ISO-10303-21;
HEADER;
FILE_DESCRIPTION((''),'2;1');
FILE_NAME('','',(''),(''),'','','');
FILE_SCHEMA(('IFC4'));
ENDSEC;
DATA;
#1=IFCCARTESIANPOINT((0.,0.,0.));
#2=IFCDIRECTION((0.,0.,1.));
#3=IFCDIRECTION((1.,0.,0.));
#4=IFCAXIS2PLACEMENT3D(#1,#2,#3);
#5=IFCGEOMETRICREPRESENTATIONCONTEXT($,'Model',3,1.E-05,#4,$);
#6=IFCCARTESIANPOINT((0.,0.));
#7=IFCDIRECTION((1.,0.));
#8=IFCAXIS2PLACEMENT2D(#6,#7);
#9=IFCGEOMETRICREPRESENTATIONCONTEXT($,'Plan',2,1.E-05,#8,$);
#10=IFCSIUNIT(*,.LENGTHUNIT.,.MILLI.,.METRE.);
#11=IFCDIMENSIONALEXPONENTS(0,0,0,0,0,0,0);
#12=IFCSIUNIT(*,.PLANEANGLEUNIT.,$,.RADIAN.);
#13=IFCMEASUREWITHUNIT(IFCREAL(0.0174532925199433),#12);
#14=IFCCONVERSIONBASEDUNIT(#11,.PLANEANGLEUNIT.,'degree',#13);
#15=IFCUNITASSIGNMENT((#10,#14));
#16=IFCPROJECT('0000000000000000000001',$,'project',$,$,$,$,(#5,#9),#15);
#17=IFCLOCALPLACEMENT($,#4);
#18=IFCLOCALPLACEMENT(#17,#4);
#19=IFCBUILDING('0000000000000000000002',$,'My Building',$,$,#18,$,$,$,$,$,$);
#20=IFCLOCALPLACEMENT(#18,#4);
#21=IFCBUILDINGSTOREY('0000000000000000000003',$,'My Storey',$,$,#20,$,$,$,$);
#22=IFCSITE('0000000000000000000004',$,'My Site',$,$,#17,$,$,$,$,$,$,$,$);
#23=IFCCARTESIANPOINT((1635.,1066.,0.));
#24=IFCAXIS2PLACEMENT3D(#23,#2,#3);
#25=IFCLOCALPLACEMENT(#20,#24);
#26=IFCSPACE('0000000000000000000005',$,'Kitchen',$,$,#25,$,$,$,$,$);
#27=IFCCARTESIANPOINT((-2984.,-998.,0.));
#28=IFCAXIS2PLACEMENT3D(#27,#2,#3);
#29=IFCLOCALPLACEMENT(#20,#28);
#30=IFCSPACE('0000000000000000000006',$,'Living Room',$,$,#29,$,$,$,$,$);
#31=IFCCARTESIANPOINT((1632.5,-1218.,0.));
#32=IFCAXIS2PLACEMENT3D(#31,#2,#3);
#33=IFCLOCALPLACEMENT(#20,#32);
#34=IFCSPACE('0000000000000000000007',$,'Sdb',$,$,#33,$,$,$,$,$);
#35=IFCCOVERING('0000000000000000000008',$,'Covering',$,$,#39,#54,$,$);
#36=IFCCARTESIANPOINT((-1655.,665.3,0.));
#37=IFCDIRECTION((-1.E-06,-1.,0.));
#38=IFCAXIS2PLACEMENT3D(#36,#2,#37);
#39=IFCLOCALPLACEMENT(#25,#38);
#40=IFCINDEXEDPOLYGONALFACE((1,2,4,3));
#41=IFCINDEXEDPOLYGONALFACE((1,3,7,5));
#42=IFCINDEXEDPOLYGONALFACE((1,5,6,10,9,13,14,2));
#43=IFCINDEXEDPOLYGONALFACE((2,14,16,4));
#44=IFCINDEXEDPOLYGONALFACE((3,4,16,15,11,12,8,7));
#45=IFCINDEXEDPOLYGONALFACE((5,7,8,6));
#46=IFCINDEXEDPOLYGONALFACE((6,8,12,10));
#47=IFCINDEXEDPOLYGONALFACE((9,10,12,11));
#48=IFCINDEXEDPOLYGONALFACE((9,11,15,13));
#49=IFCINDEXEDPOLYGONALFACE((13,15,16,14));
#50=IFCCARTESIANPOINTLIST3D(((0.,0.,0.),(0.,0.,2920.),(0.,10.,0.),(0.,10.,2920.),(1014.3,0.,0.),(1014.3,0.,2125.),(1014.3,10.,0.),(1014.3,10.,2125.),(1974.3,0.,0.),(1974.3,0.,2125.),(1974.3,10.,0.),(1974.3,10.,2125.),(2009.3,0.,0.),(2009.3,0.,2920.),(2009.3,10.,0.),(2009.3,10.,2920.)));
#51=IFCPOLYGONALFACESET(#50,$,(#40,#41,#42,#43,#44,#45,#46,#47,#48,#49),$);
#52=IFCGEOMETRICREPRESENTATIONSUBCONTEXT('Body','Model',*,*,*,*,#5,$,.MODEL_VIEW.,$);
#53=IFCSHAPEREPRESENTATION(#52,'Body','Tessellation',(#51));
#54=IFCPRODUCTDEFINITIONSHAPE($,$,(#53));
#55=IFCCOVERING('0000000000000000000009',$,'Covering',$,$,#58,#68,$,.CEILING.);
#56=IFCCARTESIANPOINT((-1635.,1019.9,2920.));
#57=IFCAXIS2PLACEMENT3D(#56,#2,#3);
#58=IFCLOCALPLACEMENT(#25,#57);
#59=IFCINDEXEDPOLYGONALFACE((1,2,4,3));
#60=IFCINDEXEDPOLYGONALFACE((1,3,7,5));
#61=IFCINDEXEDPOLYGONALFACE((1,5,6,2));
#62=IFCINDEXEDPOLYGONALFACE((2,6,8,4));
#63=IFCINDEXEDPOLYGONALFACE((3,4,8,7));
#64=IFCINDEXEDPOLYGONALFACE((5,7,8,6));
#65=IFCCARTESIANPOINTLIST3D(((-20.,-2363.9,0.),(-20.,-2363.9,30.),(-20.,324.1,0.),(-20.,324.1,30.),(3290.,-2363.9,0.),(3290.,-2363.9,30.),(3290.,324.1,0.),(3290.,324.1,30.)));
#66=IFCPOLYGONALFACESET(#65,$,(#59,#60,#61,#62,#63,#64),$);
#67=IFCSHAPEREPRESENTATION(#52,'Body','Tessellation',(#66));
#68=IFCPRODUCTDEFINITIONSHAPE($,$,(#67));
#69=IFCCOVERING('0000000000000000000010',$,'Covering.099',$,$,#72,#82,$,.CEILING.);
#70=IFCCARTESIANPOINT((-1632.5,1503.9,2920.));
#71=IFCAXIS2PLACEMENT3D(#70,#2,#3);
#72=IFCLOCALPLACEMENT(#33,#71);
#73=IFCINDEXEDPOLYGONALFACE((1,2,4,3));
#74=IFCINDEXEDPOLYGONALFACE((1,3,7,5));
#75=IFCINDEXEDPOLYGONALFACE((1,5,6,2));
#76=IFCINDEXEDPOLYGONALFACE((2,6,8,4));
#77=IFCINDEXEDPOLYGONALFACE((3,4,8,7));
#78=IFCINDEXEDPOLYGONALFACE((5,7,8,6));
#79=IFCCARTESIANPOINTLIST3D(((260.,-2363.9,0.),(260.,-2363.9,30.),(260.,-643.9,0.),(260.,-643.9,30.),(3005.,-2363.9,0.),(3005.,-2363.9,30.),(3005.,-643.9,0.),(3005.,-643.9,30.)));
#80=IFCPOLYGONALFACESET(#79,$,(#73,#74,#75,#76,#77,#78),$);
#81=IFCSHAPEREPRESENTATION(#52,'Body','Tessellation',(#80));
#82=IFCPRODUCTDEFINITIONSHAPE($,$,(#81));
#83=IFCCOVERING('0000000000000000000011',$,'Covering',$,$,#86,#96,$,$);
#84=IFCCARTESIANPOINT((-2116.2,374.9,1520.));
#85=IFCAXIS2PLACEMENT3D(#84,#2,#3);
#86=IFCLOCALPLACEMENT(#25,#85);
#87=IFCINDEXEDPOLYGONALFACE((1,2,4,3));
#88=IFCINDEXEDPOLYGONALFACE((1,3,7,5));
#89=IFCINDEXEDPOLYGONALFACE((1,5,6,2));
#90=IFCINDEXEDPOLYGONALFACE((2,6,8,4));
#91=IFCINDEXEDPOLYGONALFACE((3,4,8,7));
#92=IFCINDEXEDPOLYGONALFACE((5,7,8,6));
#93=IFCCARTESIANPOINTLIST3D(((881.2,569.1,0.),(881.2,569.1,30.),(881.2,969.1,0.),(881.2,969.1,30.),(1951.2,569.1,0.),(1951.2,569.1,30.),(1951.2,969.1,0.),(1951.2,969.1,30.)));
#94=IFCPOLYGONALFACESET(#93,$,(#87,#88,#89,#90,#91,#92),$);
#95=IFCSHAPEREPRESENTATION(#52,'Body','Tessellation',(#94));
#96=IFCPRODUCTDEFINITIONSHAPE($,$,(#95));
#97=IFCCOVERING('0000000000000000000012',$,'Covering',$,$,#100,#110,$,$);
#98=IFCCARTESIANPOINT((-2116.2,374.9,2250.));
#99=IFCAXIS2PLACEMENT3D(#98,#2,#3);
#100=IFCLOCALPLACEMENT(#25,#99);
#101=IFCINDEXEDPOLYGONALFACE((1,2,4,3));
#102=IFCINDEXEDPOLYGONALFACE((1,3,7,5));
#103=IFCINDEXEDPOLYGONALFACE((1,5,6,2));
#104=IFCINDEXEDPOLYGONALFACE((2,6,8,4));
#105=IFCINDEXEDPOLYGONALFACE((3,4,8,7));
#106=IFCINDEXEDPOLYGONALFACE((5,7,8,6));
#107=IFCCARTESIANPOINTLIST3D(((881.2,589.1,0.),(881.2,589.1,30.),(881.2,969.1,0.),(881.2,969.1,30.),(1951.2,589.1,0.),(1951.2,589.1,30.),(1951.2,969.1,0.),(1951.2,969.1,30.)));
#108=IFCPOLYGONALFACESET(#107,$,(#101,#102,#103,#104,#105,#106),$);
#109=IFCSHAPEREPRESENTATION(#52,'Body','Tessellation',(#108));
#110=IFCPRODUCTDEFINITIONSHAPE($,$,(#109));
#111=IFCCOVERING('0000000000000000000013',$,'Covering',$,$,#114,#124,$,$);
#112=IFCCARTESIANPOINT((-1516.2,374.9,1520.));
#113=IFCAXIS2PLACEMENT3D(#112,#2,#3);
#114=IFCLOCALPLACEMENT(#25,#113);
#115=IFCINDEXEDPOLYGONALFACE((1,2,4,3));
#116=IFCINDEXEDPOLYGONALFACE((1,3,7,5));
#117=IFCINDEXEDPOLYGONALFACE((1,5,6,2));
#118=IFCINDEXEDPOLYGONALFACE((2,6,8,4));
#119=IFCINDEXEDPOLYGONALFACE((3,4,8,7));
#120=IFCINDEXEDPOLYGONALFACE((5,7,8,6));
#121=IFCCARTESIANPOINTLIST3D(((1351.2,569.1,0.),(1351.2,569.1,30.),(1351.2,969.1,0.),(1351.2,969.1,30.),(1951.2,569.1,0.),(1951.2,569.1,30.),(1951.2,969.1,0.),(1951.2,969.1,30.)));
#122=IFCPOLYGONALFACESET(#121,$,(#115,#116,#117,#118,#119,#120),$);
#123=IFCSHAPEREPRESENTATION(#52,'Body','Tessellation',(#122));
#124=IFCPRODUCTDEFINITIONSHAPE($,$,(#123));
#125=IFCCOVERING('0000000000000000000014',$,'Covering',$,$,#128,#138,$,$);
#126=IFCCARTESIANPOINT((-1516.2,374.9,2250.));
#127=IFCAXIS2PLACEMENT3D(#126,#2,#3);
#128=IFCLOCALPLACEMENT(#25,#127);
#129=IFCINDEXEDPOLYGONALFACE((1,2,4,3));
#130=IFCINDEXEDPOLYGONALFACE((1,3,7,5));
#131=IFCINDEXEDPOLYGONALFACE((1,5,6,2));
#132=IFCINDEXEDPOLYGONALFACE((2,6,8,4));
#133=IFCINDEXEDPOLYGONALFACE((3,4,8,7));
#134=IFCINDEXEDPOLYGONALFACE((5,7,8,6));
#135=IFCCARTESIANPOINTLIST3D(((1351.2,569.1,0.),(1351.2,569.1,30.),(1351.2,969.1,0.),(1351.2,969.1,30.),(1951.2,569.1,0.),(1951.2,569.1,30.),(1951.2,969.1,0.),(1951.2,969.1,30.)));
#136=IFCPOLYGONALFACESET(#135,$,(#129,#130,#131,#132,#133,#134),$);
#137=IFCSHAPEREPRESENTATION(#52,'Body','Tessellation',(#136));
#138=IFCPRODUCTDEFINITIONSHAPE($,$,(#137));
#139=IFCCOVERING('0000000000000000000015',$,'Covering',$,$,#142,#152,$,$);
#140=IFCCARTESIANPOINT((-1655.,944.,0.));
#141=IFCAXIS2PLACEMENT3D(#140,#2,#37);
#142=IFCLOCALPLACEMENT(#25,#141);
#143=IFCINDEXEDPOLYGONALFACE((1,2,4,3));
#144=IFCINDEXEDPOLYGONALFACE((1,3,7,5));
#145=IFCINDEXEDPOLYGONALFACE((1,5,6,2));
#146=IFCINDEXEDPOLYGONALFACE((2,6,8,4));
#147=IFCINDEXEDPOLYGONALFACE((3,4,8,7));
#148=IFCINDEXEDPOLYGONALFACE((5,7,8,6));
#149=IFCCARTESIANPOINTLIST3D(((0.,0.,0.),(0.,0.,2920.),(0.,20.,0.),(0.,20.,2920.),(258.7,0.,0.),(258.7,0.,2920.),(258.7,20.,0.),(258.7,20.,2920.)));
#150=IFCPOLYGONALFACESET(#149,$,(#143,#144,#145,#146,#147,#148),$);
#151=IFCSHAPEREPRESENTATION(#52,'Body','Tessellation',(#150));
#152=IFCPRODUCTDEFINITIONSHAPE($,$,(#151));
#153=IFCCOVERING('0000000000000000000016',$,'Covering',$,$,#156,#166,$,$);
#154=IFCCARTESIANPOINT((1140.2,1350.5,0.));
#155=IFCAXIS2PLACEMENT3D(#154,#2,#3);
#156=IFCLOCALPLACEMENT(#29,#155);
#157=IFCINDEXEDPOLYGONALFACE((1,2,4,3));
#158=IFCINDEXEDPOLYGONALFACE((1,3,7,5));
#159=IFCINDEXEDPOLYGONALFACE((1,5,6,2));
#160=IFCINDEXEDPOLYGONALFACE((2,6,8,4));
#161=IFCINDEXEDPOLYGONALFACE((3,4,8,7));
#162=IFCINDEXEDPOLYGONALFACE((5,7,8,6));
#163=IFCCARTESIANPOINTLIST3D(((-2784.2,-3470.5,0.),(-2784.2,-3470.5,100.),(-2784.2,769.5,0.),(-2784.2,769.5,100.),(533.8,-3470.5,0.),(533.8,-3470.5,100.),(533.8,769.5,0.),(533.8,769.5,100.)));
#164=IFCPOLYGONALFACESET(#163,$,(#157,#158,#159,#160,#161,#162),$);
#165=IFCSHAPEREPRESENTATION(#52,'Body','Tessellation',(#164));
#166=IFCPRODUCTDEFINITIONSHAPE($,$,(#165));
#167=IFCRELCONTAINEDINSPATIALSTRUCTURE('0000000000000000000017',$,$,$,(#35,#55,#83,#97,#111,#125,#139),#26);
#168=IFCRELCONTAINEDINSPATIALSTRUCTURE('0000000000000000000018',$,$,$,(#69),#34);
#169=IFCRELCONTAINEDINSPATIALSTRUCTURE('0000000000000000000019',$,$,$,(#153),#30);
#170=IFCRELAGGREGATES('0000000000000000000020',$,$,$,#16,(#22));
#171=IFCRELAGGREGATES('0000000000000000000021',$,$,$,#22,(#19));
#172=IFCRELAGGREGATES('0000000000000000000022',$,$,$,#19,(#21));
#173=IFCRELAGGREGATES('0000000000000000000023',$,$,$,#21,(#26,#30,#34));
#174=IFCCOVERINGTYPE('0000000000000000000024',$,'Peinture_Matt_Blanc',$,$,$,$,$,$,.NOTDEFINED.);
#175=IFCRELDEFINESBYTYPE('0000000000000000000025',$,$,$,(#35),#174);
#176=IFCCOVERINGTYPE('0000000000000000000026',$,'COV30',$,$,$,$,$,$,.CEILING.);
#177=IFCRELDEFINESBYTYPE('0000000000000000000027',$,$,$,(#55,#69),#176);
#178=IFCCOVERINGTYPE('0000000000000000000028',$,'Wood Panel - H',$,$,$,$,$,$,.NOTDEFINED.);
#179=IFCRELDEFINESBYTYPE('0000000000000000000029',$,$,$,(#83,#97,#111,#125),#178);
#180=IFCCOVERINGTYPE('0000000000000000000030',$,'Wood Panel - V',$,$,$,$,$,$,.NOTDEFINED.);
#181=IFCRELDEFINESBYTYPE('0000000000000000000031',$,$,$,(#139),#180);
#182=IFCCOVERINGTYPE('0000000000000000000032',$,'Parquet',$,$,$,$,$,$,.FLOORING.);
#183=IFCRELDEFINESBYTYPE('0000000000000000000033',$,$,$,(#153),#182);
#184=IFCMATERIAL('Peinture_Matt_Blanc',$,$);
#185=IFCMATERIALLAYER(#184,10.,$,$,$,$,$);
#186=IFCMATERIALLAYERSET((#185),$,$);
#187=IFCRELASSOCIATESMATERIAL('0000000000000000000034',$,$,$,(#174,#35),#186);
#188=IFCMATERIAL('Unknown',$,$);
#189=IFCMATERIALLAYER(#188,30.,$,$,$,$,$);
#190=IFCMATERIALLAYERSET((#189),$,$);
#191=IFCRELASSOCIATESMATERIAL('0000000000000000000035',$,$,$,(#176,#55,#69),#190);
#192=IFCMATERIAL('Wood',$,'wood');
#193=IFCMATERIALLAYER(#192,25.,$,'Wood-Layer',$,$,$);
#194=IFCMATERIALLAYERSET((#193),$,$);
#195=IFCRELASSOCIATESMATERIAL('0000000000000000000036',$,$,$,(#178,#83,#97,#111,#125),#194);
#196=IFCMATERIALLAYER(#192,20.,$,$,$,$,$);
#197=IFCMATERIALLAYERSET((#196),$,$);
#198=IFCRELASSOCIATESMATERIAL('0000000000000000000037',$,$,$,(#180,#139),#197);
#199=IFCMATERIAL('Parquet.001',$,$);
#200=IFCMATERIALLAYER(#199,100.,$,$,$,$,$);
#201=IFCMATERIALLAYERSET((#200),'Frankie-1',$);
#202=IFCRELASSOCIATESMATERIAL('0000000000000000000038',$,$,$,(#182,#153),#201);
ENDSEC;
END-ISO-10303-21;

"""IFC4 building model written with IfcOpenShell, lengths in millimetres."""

from ifc_helpers import new_model, entity, si_unit, converted_unit, frame, origin_with_axes, origin_2d_with_axis, place, context, subcontext, project, spatial, line, indexed_curve, outline, extrude, clip, halfspace, source, transform, mapped, material, layer, layer_set, layer_usage, type_object, element, save


model = new_model("IFC4")

# Units and contexts
model_context = context("Model", 3, precision=1e-05, world=origin_with_axes())
plan_context = context("Plan", 2, precision=1e-05, world=origin_2d_with_axis())
body_context_1 = subcontext(model_context, "Body", "Model", "MODEL_VIEW")
ifc_project = project(units=[si_unit("LENGTHUNIT", "METRE", prefix="MILLI"), converted_unit("PLANEANGLEUNIT", "degree", entity("IfcReal", 0.0174532925199433), si_unit("PLANEANGLEUNIT", "RADIAN"), dimensions=[0, 0, 0, 0, 0, 0, 0])], contexts=[model_context, plan_context])

# Site, building, storey
site_placement = place(None, origin_with_axes())
site = spatial("IfcSite", under=ifc_project, at=site_placement, Name="My Site")
building_placement = place(site_placement, origin_with_axes())
building = spatial("IfcBuilding", under=site, at=building_placement, Name="My Building")
storey_placement = place(building_placement, origin_with_axes())
storey = spatial("IfcBuildingStorey", under=building, at=storey_placement, Name="My Storey")

# Shared definitions
ifc_material_1 = material(Name="Unknown")

# Shared definitions
space_1_placement = place(storey_placement, frame((1635.0, 1066.0, 0.0), z_axis=(0.0, 0.0, 1.0), x_axis=(1.0, 0.0, 0.0)))
space_1 = spatial("IfcSpace", under=storey, at=space_1_placement, Name="Kitchen")

# Shared definitions
ifc_material_2 = material(Name="Peinture_Matt_Blanc")
ifc_layer_1 = layer(ifc_material_2, 10.0)
ifc_layer_set_1 = layer_set([ifc_layer_1])
covering_type_1 = type_object("IfcCoveringType", Name="Peinture_Matt_Blanc", PredefinedType="NOTDEFINED", material=ifc_layer_set_1)

# Shared definitions
space_2_placement = place(storey_placement, frame((-2984.0, -998.0, 0.0), z_axis=(0.0, 0.0, 1.0), x_axis=(1.0, 0.0, 0.0)))
space_2 = spatial("IfcSpace", under=storey, at=space_2_placement, Name="Living Room")

# Covering, opening
ifc_layer_usage_1 = layer_usage(ifc_layer_set_1, "AXIS2", "POSITIVE", 0.0)
covering_1_placement = place(space_1_placement, frame((-1655.0, 665.3, 0.0), z_axis=(0.0, 0.0, 1.0), x_axis=(-0.000001, -1.0, 0.0)))
covering_1 = element("IfcCovering", 1, at=covering_1_placement, inside=space_1, type_object=covering_type_1, material=ifc_layer_usage_1, Name="Covering", context=body_context_1, shape_type="Clipping", body=[
    clip(clip(extrude(outline(indexed_curve([(0.0, 0.0), (0.0, 10.0), (2009.3, 10.0), (2009.3, 0.0), (0.0, 0.0)], self_intersect=False)), origin_with_axes(), (0.0, 0.0, 1.0), 2920.0), halfspace(frame((0.0, 0.0, 2920.0), z_axis=(0.0, 0.0, 1.0), x_axis=(-1.0, 0.0, 0.0)), False)), halfspace(frame((0.0, 0.0, 2920.0), z_axis=(0.0, 0.0, 1.0), x_axis=(-1.0, 0.0, 0.0)), False)),
])
shared_shape_1 = source(origin_with_axes(), body_context_1, "Body", "SweptSolid", [
    extrude(outline(indexed_curve([(0.0, 0.0), (960.0, 0.0), (960.0, 2125.0), (0.0, 2125.0)], segments=[line(4, 1), line(1, 2), line(2, 3), line(3, 4)], self_intersect=False)), frame((0.0, -600.0, 0.0), z_axis=(0.0, -1.0, 0.0), x_axis=(1.0, 0.0, 0.0)), (0.0, 0.0, -1.0), 1200.0),
])
opening_1_placement = place(covering_1_placement, frame((1974.3, 0.0, 0.0), z_axis=(0.0, 0.0, 1.0), x_axis=(-1.0, 0.0, 0.0)))
element("IfcOpeningElement", 2, at=opening_1_placement, cuts=covering_1, PredefinedType="OPENING", context=body_context_1, shape_type="MappedRepresentation", body=[
    mapped(shared_shape_1, transform((0.0, 0.0, 0.0), x_axis=(1.0, 0.0, 0.0), y_axis=(0.0, 1.0, 0.0), z_axis=(0.0, 0.0, 1.0), scale=1.0)),
])

# Covering
ifc_layer_2 = layer(ifc_material_1, 30.0)
ifc_layer_set_2 = layer_set([ifc_layer_2])
ifc_layer_usage_2 = layer_usage(ifc_layer_set_2, "AXIS3", "POSITIVE", 0.0)
covering_type_2 = type_object("IfcCoveringType", Name="COV30", PredefinedType="CEILING", material=ifc_layer_set_2)
covering_2_placement = place(space_1_placement, frame((-1635.0, 1019.9, 2920.0), z_axis=(0.0, 0.0, 1.0), x_axis=(1.0, 0.0, 0.0)))
element("IfcCovering", 3, at=covering_2_placement, inside=space_1, type_object=covering_type_2, material=ifc_layer_usage_2, Name="Covering", PredefinedType="CEILING", context=body_context_1, shape_type="SweptSolid", body=[
    extrude(outline(indexed_curve([(-20.0, 324.1), (-20.0, -2363.9), (3290.0, -2363.9), (3290.0, 324.1)], segments=[line(3, 2), line(2, 1), line(1, 4), line(4, 3)], self_intersect=False)), None, (0.0, 0.0, 1.0), 30.0),
])

# Shared definitions
space_3_placement = place(storey_placement, frame((1632.5, -1218.0, 0.0), z_axis=(0.0, 0.0, 1.0), x_axis=(1.0, 0.0, 0.0)))
space_3 = spatial("IfcSpace", under=storey, at=space_3_placement, Name="Sdb")

# Coverings
ifc_layer_usage_3 = layer_usage(ifc_layer_set_2, "AXIS3", "POSITIVE", 0.0)
covering_3_placement = place(space_3_placement, frame((-1632.5, 1503.9, 2920.0), z_axis=(0.0, 0.0, 1.0), x_axis=(1.0, 0.0, 0.0)))
element("IfcCovering", 4, at=covering_3_placement, inside=space_3, type_object=covering_type_2, material=ifc_layer_usage_3, Name="Covering.099", PredefinedType="CEILING", context=body_context_1, shape_type="SweptSolid", body=[
    extrude(outline(indexed_curve([(3005.0, -2363.9), (260.0, -2363.9), (260.0, -643.9), (3005.0, -643.9)], segments=[line(3, 2), line(2, 1), line(1, 4), line(4, 3)], self_intersect=False)), None, (0.0, 0.0, 1.0), 30.0),
])
ifc_material_3 = material(Name="Wood", Category="wood")
ifc_layer_3 = layer(ifc_material_3, 25.0, Name="Wood-Layer")
ifc_layer_set_3 = layer_set([ifc_layer_3])
ifc_layer_usage_4 = layer_usage(ifc_layer_set_3, "AXIS3", "POSITIVE", 0.0)
covering_type_3 = type_object("IfcCoveringType", Name="Wood Panel - H", PredefinedType="NOTDEFINED", material=ifc_layer_set_3)
covering_4_placement = place(space_1_placement, frame((-2116.2, 374.9, 1520.0), z_axis=(0.0, 0.0, 1.0), x_axis=(1.0, 0.0, 0.0)))
element("IfcCovering", 5, at=covering_4_placement, inside=space_1, type_object=covering_type_3, material=ifc_layer_usage_4, Name="Covering", context=body_context_1, shape_type="SweptSolid", body=[
    extrude(outline(indexed_curve([(1951.2, 969.1), (1951.2, 569.1), (881.2, 569.1), (881.2, 969.1)], segments=[line(3, 2), line(2, 1), line(1, 4), line(4, 3)], self_intersect=False)), None, (0.0, 0.0, 1.0), 30.0),
])
ifc_layer_usage_5 = layer_usage(ifc_layer_set_3, "AXIS3", "POSITIVE", 0.0)
covering_5_placement = place(space_1_placement, frame((-2116.2, 374.9, 2250.0), z_axis=(0.0, 0.0, 1.0), x_axis=(1.0, 0.0, 0.0)))
element("IfcCovering", 6, at=covering_5_placement, inside=space_1, type_object=covering_type_3, material=ifc_layer_usage_5, Name="Covering", context=body_context_1, shape_type="SweptSolid", body=[
    extrude(outline(indexed_curve([(1951.2, 969.1), (1951.2, 589.1), (881.2, 589.1), (881.2, 969.1)], segments=[line(3, 2), line(2, 1), line(1, 4), line(4, 3)], self_intersect=False)), None, (0.0, 0.0, 1.0), 30.0),
])
ifc_layer_usage_6 = layer_usage(ifc_layer_set_3, "AXIS3", "POSITIVE", 0.0)
covering_6_placement = place(space_1_placement, frame((-1516.2, 374.9, 1520.0), z_axis=(0.0, 0.0, 1.0), x_axis=(1.0, 0.0, 0.0)))
element("IfcCovering", 7, at=covering_6_placement, inside=space_1, type_object=covering_type_3, material=ifc_layer_usage_6, Name="Covering", context=body_context_1, shape_type="SweptSolid", body=[
    extrude(outline(indexed_curve([(1351.2, 569.1), (1951.2, 569.1), (1951.2, 969.1), (1351.2, 969.1)], segments=[line(3, 2), line(2, 1), line(1, 4), line(4, 3)], self_intersect=False)), None, (0.0, 0.0, 1.0), 30.0),
])
ifc_layer_usage_7 = layer_usage(ifc_layer_set_3, "AXIS3", "POSITIVE", 0.0)
covering_7_placement = place(space_1_placement, frame((-1516.2, 374.9, 2250.0), z_axis=(0.0, 0.0, 1.0), x_axis=(1.0, 0.0, 0.0)))
element("IfcCovering", 8, at=covering_7_placement, inside=space_1, type_object=covering_type_3, material=ifc_layer_usage_7, Name="Covering", context=body_context_1, shape_type="SweptSolid", body=[
    extrude(outline(indexed_curve([(1351.2, 569.1), (1951.2, 569.1), (1951.2, 969.1), (1351.2, 969.1)], segments=[line(4, 1), line(1, 2), line(2, 3), line(3, 4)], self_intersect=False)), None, (0.0, 0.0, 1.0), 30.0),
])
ifc_layer_4 = layer(ifc_material_3, 20.0)
ifc_layer_set_4 = layer_set([ifc_layer_4])
ifc_layer_usage_8 = layer_usage(ifc_layer_set_4, "AXIS2", "POSITIVE", 0.0)
covering_type_4 = type_object("IfcCoveringType", Name="Wood Panel - V", PredefinedType="NOTDEFINED", material=ifc_layer_set_4)
covering_8_placement = place(space_1_placement, frame((-1655.0, 944.0, 0.0), z_axis=(0.0, 0.0, 1.0), x_axis=(-0.000001, -1.0, 0.0)))
element("IfcCovering", 9, at=covering_8_placement, inside=space_1, type_object=covering_type_4, material=ifc_layer_usage_8, Name="Covering", context=body_context_1, shape_type="Clipping", body=[
    clip(extrude(outline(indexed_curve([(0.0, 0.0), (0.0, 20.0), (258.7, 20.0), (258.7, 0.0), (0.0, 0.0)], self_intersect=False)), origin_with_axes(), (0.0, 0.0, 1.0), 2920.0), halfspace(frame((0.0, 0.0, 2920.0), z_axis=(0.0, 0.0, 1.0), x_axis=(-1.0, 0.0, 0.0)), False)),
])
ifc_material_4 = material(Name="Parquet.001")
ifc_layer_5 = layer(ifc_material_4, 100.0)
ifc_layer_set_5 = layer_set([ifc_layer_5], Name="Frankie-1")
ifc_layer_usage_9 = layer_usage(ifc_layer_set_5, "AXIS3", "POSITIVE", 0.0)
covering_type_5 = type_object("IfcCoveringType", Name="Parquet", PredefinedType="FLOORING", material=ifc_layer_set_5)
covering_9_placement = place(space_2_placement, frame((1140.2, 1350.5, 0.0), z_axis=(0.0, 0.0, 1.0), x_axis=(1.0, 0.0, 0.0)))
element("IfcCovering", 10, at=covering_9_placement, inside=space_2, type_object=covering_type_5, material=ifc_layer_usage_9, Name="Covering", context=body_context_1, shape_type="SweptSolid", body=[
    extrude(outline(indexed_curve([(-2784.2, -3470.5), (-2784.2, 769.5), (533.8, 769.5), (533.8, -3470.5)], segments=[line(3, 2), line(2, 1), line(1, 4), line(4, 3)], self_intersect=False)), None, (0.0, 0.0, 1.0), 100.0),
])

save(model, "model.ifc")
